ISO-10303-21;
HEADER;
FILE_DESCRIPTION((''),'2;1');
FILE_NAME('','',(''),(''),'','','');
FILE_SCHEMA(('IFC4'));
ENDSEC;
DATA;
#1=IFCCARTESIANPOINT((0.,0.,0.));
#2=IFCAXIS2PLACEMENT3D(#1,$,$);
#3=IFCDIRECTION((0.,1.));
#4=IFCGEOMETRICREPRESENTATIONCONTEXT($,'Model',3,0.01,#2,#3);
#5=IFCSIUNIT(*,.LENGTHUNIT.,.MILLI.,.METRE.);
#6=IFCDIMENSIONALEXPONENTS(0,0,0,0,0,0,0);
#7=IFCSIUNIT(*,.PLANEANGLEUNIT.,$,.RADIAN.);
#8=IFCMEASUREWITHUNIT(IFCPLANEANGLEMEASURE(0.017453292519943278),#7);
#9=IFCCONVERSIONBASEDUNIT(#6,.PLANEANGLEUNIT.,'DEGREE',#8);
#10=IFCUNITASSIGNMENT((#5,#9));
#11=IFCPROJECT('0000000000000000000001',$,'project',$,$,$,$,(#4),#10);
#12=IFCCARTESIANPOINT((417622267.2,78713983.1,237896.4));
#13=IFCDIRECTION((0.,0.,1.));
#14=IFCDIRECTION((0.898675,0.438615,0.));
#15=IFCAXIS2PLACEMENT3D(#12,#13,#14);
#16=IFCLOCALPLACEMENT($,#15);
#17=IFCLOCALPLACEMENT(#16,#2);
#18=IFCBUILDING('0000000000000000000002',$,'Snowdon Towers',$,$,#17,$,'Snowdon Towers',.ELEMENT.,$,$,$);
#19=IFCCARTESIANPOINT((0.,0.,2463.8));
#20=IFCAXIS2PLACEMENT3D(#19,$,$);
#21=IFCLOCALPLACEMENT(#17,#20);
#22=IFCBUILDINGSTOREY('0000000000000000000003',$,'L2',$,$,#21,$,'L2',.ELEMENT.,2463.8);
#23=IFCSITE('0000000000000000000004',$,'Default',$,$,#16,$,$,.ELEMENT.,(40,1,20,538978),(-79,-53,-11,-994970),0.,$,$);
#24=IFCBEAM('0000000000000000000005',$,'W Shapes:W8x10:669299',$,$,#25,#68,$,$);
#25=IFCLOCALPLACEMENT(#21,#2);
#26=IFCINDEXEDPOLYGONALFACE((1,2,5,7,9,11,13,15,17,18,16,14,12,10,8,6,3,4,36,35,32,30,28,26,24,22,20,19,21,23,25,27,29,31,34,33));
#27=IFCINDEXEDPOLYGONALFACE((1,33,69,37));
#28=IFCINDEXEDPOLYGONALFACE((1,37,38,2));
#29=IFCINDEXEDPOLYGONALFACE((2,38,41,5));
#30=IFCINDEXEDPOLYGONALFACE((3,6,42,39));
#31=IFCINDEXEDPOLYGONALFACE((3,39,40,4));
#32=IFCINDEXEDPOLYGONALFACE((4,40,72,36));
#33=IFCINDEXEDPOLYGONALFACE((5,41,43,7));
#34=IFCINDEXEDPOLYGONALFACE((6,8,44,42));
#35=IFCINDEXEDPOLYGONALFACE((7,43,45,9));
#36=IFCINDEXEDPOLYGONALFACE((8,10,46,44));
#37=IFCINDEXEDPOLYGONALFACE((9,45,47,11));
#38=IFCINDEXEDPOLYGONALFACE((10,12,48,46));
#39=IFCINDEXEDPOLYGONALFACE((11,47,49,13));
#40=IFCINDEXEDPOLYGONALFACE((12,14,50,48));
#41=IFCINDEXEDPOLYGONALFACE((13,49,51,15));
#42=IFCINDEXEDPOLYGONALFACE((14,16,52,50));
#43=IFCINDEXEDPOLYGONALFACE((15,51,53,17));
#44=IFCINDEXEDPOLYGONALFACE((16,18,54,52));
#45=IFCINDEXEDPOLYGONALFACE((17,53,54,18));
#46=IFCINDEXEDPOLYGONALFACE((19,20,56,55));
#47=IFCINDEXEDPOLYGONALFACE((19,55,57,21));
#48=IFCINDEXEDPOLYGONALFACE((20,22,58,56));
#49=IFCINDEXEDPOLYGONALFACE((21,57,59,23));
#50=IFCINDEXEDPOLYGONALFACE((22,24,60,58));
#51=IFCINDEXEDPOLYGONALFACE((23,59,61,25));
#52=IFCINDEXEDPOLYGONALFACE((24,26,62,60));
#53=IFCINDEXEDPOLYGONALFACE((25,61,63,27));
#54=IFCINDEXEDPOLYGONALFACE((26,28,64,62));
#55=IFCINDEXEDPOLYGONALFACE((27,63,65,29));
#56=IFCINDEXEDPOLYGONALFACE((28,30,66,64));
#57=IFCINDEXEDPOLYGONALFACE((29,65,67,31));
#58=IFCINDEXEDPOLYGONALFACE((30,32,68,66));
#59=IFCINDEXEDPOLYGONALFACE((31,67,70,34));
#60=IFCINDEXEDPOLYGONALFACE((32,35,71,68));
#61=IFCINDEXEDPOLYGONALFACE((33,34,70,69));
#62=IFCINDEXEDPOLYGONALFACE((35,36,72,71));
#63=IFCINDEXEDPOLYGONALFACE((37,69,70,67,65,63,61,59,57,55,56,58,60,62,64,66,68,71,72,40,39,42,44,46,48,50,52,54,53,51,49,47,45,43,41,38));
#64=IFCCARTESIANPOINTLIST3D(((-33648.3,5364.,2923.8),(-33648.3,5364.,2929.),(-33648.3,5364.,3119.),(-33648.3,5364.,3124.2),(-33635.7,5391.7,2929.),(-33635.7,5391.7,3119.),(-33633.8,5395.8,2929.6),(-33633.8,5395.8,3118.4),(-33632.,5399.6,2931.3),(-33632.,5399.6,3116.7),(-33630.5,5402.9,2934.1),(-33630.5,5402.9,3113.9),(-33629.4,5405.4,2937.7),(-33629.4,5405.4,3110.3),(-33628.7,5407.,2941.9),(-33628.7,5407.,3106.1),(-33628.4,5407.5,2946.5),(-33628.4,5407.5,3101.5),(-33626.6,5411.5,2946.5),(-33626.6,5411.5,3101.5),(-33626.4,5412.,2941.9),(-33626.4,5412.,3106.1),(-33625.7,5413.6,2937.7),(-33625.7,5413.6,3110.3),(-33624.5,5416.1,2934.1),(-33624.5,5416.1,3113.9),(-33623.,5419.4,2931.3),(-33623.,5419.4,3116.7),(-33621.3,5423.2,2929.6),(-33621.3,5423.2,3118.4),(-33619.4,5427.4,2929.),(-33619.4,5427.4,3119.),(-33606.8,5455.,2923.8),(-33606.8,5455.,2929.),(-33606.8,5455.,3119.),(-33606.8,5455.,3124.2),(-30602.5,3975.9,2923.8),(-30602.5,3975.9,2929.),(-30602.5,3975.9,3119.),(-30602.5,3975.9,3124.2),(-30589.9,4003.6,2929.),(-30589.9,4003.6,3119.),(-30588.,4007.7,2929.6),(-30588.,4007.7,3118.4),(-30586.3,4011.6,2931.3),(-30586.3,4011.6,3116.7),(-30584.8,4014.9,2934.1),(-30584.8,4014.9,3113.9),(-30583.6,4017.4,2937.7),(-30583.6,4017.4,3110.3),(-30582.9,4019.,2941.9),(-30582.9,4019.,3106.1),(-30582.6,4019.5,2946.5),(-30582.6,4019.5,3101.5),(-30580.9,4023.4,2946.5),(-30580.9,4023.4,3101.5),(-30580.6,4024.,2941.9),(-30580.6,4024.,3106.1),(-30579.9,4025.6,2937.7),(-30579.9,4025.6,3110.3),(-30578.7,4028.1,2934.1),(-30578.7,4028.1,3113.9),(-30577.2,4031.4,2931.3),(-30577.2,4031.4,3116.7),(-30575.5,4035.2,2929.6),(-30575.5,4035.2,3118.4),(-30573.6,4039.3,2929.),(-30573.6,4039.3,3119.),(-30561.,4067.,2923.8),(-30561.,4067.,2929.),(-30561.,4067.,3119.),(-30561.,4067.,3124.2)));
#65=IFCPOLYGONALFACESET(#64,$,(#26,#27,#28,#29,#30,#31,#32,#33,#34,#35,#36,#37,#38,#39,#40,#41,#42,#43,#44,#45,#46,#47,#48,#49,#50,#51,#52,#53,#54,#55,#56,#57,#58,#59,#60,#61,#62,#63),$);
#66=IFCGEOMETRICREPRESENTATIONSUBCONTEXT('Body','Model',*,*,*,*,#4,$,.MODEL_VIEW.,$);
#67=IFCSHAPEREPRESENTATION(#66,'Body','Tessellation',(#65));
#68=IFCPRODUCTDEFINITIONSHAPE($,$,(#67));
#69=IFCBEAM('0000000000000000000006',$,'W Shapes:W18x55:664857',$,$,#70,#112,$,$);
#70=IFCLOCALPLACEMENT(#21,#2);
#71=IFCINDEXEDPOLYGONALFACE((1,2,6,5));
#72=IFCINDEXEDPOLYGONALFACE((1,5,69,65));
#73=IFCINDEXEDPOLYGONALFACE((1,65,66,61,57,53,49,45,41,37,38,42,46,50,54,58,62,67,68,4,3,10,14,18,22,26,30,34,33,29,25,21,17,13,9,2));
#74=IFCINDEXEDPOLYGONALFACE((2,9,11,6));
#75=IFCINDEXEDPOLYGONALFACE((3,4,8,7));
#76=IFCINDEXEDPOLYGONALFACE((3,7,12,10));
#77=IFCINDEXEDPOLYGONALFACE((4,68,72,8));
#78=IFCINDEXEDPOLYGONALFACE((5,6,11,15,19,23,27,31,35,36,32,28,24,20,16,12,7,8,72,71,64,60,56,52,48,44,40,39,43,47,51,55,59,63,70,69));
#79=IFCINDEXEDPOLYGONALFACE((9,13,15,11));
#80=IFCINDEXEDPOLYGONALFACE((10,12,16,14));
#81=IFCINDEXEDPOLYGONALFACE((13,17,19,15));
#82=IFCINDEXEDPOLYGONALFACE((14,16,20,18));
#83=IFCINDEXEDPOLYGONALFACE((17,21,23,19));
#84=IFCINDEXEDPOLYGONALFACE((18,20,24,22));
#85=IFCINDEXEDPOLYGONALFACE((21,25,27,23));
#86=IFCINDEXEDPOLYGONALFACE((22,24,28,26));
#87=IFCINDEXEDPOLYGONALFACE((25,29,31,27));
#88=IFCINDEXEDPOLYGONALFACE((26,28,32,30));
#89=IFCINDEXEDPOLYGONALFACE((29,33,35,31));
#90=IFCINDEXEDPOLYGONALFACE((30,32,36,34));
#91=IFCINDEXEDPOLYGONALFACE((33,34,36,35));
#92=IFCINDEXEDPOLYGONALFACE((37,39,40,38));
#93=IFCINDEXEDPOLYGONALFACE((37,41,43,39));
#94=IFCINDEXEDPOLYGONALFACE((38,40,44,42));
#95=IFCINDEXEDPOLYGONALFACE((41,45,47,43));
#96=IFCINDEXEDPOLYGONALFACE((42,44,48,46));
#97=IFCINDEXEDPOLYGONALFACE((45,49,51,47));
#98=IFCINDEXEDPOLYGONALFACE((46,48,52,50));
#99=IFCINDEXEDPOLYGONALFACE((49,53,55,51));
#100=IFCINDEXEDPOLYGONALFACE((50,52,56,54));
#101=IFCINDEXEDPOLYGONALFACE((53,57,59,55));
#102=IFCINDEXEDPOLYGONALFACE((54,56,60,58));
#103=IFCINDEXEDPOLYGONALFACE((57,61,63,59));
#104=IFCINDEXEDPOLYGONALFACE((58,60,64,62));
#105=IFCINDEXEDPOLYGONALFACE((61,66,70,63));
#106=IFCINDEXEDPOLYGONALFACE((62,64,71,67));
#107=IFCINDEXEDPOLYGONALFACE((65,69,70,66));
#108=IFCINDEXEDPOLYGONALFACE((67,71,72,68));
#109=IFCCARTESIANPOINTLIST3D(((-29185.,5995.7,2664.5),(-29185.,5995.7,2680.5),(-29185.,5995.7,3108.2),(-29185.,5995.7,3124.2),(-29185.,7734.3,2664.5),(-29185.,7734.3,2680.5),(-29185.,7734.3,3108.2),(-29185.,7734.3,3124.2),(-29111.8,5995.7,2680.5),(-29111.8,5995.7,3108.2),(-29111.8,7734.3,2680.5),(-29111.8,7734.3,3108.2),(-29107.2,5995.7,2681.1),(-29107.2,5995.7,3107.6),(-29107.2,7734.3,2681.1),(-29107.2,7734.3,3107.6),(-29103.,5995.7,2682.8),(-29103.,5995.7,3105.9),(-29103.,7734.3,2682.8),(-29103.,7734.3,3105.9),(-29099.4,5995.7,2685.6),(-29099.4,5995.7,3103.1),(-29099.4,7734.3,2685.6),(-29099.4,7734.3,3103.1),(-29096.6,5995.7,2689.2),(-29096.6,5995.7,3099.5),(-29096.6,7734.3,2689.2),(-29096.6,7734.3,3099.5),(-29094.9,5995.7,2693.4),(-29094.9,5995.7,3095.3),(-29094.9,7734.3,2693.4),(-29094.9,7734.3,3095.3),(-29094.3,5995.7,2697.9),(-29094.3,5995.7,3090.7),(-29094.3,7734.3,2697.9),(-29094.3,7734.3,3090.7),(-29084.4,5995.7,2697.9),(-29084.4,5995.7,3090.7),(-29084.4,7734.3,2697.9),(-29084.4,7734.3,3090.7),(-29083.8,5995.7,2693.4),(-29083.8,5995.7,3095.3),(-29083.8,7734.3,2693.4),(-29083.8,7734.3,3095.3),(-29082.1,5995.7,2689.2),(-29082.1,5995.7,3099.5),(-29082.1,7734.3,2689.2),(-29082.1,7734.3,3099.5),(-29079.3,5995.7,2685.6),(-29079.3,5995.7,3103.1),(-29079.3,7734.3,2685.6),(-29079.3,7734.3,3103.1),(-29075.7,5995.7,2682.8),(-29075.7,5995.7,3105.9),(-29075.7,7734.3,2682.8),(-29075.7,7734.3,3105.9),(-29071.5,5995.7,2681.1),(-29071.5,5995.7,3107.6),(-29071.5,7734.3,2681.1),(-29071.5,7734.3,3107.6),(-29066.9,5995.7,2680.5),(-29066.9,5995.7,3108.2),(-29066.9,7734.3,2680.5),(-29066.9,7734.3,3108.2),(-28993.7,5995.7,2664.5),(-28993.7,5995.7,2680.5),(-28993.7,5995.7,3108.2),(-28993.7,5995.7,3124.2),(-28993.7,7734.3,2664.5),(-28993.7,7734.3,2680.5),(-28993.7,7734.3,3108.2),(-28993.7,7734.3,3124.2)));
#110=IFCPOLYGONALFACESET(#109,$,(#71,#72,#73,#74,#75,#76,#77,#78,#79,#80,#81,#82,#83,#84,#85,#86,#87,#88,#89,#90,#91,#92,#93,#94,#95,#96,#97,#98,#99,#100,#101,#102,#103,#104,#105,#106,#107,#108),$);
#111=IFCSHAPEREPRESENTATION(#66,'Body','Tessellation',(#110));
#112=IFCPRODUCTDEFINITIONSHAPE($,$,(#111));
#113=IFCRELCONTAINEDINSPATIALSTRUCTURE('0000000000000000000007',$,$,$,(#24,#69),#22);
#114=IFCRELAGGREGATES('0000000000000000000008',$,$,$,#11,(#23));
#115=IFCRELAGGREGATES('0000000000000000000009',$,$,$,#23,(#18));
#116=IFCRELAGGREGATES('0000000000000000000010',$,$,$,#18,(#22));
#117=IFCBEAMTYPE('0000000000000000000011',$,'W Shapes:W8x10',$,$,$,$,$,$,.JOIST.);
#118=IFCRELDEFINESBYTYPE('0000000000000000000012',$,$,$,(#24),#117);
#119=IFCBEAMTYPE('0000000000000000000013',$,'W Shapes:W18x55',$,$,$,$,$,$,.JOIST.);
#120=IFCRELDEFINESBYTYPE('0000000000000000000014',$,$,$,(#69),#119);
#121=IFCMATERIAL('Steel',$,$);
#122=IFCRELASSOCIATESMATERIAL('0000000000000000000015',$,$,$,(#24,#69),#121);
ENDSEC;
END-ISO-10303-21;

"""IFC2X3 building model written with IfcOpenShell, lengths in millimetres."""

from ifc_helpers import new_model, entity, si_unit, converted_unit, direction, frame, frame_2d, origin, place, context, subcontext, project, spatial, i_section, extrude, material, type_object, element, save


model = new_model("IFC2X3")

# Units and contexts
model_context = context("Model", 3, precision=0.01, world=origin(), true_north=direction((0.0, 1.0)))
body_context = subcontext(model_context, "Body", "Model", "MODEL_VIEW")
ifc_project = project(units=[si_unit("LENGTHUNIT", "METRE", prefix="MILLI"), converted_unit("PLANEANGLEUNIT", "DEGREE", entity("IfcPlaneAngleMeasure", 0.017453292519943278), si_unit("PLANEANGLEUNIT", "RADIAN"), dimensions=[0, 0, 0, 0, 0, 0, 0])], contexts=[model_context])

# Site, building, storey
site_placement = place(None, frame((417622267.2, 78713983.1, 237896.4), z_axis=(0.0, 0.0, 1.0), x_axis=(0.898675, 0.438615, 0.0)))
site = spatial("IfcSite", under=ifc_project, at=site_placement, Name="Default", CompositionType="ELEMENT", RefLatitude=(40, 1, 20, 538978), RefLongitude=(-79, -53, -11, -994970), RefElevation=0.0)
building_placement = place(site_placement, origin())
building = spatial("IfcBuilding", under=site, at=building_placement, Name="Snowdon Towers", LongName="Snowdon Towers", CompositionType="ELEMENT")
storey_placement = place(building_placement, frame((0.0, 0.0, 2463.8)))
storey = spatial("IfcBuildingStorey", under=building, at=storey_placement, Name="L2", LongName="L2", CompositionType="ELEMENT", Elevation=2463.8)

# Beams
ifc_material = material(Name="Steel")
beam_type_1 = type_object("IfcBeamType", Name="W Shapes:W8x10", PredefinedType="JOIST")
beam_1_placement = place(storey_placement, frame((-33743.9, 5462.5, 3124.2), z_axis=(0.0, 0.0, 1.0), x_axis=(0.909961, -0.414693, 0.0)))
element("IfcBeam", 1, at=beam_1_placement, inside=storey, type_object=beam_type_1, material=ifc_material, Name="W Shapes:W8x10:669299", context=body_context, shape_type="SweptSolid", body=[
    extrude(i_section(OverallWidth=100.1, OverallDepth=200.4, WebThickness=4.3, FlangeThickness=5.2, FilletRadius=17.5, at=frame_2d((0.0, 0.0), x_axis=(0.0, 1.0))), frame((127.9, 0.0, -100.2), z_axis=(1.0, 0.0, 0.0), x_axis=(0.0, 0.0, -1.0)), (0.0, 0.0, 1.0), 3347.1),
])
beam_type_2 = type_object("IfcBeamType", Name="W Shapes:W18x55", PredefinedType="JOIST")
beam_2_placement = place(storey_placement, frame((-29089.3, 5854.7, 3124.2), z_axis=(0.0, 0.0, 1.0), x_axis=(0.0, 1.0, 0.0)))
element("IfcBeam", 2, at=beam_2_placement, inside=storey, type_object=beam_type_2, material=ifc_material, Name="W Shapes:W18x55:664857", context=body_context, shape_type="SweptSolid", body=[
    extrude(i_section(OverallWidth=191.3, OverallDepth=459.7, WebThickness=9.9, FlangeThickness=16.0, FilletRadius=17.5, at=frame_2d((0.0, 0.0), x_axis=(0.0, 1.0))), frame((141.0, 0.0, -229.9), z_axis=(1.0, 0.0, 0.0), x_axis=(0.0, 0.0, -1.0)), (0.0, 0.0, 1.0), 1738.6),
])

save(model, "model.ifc")
